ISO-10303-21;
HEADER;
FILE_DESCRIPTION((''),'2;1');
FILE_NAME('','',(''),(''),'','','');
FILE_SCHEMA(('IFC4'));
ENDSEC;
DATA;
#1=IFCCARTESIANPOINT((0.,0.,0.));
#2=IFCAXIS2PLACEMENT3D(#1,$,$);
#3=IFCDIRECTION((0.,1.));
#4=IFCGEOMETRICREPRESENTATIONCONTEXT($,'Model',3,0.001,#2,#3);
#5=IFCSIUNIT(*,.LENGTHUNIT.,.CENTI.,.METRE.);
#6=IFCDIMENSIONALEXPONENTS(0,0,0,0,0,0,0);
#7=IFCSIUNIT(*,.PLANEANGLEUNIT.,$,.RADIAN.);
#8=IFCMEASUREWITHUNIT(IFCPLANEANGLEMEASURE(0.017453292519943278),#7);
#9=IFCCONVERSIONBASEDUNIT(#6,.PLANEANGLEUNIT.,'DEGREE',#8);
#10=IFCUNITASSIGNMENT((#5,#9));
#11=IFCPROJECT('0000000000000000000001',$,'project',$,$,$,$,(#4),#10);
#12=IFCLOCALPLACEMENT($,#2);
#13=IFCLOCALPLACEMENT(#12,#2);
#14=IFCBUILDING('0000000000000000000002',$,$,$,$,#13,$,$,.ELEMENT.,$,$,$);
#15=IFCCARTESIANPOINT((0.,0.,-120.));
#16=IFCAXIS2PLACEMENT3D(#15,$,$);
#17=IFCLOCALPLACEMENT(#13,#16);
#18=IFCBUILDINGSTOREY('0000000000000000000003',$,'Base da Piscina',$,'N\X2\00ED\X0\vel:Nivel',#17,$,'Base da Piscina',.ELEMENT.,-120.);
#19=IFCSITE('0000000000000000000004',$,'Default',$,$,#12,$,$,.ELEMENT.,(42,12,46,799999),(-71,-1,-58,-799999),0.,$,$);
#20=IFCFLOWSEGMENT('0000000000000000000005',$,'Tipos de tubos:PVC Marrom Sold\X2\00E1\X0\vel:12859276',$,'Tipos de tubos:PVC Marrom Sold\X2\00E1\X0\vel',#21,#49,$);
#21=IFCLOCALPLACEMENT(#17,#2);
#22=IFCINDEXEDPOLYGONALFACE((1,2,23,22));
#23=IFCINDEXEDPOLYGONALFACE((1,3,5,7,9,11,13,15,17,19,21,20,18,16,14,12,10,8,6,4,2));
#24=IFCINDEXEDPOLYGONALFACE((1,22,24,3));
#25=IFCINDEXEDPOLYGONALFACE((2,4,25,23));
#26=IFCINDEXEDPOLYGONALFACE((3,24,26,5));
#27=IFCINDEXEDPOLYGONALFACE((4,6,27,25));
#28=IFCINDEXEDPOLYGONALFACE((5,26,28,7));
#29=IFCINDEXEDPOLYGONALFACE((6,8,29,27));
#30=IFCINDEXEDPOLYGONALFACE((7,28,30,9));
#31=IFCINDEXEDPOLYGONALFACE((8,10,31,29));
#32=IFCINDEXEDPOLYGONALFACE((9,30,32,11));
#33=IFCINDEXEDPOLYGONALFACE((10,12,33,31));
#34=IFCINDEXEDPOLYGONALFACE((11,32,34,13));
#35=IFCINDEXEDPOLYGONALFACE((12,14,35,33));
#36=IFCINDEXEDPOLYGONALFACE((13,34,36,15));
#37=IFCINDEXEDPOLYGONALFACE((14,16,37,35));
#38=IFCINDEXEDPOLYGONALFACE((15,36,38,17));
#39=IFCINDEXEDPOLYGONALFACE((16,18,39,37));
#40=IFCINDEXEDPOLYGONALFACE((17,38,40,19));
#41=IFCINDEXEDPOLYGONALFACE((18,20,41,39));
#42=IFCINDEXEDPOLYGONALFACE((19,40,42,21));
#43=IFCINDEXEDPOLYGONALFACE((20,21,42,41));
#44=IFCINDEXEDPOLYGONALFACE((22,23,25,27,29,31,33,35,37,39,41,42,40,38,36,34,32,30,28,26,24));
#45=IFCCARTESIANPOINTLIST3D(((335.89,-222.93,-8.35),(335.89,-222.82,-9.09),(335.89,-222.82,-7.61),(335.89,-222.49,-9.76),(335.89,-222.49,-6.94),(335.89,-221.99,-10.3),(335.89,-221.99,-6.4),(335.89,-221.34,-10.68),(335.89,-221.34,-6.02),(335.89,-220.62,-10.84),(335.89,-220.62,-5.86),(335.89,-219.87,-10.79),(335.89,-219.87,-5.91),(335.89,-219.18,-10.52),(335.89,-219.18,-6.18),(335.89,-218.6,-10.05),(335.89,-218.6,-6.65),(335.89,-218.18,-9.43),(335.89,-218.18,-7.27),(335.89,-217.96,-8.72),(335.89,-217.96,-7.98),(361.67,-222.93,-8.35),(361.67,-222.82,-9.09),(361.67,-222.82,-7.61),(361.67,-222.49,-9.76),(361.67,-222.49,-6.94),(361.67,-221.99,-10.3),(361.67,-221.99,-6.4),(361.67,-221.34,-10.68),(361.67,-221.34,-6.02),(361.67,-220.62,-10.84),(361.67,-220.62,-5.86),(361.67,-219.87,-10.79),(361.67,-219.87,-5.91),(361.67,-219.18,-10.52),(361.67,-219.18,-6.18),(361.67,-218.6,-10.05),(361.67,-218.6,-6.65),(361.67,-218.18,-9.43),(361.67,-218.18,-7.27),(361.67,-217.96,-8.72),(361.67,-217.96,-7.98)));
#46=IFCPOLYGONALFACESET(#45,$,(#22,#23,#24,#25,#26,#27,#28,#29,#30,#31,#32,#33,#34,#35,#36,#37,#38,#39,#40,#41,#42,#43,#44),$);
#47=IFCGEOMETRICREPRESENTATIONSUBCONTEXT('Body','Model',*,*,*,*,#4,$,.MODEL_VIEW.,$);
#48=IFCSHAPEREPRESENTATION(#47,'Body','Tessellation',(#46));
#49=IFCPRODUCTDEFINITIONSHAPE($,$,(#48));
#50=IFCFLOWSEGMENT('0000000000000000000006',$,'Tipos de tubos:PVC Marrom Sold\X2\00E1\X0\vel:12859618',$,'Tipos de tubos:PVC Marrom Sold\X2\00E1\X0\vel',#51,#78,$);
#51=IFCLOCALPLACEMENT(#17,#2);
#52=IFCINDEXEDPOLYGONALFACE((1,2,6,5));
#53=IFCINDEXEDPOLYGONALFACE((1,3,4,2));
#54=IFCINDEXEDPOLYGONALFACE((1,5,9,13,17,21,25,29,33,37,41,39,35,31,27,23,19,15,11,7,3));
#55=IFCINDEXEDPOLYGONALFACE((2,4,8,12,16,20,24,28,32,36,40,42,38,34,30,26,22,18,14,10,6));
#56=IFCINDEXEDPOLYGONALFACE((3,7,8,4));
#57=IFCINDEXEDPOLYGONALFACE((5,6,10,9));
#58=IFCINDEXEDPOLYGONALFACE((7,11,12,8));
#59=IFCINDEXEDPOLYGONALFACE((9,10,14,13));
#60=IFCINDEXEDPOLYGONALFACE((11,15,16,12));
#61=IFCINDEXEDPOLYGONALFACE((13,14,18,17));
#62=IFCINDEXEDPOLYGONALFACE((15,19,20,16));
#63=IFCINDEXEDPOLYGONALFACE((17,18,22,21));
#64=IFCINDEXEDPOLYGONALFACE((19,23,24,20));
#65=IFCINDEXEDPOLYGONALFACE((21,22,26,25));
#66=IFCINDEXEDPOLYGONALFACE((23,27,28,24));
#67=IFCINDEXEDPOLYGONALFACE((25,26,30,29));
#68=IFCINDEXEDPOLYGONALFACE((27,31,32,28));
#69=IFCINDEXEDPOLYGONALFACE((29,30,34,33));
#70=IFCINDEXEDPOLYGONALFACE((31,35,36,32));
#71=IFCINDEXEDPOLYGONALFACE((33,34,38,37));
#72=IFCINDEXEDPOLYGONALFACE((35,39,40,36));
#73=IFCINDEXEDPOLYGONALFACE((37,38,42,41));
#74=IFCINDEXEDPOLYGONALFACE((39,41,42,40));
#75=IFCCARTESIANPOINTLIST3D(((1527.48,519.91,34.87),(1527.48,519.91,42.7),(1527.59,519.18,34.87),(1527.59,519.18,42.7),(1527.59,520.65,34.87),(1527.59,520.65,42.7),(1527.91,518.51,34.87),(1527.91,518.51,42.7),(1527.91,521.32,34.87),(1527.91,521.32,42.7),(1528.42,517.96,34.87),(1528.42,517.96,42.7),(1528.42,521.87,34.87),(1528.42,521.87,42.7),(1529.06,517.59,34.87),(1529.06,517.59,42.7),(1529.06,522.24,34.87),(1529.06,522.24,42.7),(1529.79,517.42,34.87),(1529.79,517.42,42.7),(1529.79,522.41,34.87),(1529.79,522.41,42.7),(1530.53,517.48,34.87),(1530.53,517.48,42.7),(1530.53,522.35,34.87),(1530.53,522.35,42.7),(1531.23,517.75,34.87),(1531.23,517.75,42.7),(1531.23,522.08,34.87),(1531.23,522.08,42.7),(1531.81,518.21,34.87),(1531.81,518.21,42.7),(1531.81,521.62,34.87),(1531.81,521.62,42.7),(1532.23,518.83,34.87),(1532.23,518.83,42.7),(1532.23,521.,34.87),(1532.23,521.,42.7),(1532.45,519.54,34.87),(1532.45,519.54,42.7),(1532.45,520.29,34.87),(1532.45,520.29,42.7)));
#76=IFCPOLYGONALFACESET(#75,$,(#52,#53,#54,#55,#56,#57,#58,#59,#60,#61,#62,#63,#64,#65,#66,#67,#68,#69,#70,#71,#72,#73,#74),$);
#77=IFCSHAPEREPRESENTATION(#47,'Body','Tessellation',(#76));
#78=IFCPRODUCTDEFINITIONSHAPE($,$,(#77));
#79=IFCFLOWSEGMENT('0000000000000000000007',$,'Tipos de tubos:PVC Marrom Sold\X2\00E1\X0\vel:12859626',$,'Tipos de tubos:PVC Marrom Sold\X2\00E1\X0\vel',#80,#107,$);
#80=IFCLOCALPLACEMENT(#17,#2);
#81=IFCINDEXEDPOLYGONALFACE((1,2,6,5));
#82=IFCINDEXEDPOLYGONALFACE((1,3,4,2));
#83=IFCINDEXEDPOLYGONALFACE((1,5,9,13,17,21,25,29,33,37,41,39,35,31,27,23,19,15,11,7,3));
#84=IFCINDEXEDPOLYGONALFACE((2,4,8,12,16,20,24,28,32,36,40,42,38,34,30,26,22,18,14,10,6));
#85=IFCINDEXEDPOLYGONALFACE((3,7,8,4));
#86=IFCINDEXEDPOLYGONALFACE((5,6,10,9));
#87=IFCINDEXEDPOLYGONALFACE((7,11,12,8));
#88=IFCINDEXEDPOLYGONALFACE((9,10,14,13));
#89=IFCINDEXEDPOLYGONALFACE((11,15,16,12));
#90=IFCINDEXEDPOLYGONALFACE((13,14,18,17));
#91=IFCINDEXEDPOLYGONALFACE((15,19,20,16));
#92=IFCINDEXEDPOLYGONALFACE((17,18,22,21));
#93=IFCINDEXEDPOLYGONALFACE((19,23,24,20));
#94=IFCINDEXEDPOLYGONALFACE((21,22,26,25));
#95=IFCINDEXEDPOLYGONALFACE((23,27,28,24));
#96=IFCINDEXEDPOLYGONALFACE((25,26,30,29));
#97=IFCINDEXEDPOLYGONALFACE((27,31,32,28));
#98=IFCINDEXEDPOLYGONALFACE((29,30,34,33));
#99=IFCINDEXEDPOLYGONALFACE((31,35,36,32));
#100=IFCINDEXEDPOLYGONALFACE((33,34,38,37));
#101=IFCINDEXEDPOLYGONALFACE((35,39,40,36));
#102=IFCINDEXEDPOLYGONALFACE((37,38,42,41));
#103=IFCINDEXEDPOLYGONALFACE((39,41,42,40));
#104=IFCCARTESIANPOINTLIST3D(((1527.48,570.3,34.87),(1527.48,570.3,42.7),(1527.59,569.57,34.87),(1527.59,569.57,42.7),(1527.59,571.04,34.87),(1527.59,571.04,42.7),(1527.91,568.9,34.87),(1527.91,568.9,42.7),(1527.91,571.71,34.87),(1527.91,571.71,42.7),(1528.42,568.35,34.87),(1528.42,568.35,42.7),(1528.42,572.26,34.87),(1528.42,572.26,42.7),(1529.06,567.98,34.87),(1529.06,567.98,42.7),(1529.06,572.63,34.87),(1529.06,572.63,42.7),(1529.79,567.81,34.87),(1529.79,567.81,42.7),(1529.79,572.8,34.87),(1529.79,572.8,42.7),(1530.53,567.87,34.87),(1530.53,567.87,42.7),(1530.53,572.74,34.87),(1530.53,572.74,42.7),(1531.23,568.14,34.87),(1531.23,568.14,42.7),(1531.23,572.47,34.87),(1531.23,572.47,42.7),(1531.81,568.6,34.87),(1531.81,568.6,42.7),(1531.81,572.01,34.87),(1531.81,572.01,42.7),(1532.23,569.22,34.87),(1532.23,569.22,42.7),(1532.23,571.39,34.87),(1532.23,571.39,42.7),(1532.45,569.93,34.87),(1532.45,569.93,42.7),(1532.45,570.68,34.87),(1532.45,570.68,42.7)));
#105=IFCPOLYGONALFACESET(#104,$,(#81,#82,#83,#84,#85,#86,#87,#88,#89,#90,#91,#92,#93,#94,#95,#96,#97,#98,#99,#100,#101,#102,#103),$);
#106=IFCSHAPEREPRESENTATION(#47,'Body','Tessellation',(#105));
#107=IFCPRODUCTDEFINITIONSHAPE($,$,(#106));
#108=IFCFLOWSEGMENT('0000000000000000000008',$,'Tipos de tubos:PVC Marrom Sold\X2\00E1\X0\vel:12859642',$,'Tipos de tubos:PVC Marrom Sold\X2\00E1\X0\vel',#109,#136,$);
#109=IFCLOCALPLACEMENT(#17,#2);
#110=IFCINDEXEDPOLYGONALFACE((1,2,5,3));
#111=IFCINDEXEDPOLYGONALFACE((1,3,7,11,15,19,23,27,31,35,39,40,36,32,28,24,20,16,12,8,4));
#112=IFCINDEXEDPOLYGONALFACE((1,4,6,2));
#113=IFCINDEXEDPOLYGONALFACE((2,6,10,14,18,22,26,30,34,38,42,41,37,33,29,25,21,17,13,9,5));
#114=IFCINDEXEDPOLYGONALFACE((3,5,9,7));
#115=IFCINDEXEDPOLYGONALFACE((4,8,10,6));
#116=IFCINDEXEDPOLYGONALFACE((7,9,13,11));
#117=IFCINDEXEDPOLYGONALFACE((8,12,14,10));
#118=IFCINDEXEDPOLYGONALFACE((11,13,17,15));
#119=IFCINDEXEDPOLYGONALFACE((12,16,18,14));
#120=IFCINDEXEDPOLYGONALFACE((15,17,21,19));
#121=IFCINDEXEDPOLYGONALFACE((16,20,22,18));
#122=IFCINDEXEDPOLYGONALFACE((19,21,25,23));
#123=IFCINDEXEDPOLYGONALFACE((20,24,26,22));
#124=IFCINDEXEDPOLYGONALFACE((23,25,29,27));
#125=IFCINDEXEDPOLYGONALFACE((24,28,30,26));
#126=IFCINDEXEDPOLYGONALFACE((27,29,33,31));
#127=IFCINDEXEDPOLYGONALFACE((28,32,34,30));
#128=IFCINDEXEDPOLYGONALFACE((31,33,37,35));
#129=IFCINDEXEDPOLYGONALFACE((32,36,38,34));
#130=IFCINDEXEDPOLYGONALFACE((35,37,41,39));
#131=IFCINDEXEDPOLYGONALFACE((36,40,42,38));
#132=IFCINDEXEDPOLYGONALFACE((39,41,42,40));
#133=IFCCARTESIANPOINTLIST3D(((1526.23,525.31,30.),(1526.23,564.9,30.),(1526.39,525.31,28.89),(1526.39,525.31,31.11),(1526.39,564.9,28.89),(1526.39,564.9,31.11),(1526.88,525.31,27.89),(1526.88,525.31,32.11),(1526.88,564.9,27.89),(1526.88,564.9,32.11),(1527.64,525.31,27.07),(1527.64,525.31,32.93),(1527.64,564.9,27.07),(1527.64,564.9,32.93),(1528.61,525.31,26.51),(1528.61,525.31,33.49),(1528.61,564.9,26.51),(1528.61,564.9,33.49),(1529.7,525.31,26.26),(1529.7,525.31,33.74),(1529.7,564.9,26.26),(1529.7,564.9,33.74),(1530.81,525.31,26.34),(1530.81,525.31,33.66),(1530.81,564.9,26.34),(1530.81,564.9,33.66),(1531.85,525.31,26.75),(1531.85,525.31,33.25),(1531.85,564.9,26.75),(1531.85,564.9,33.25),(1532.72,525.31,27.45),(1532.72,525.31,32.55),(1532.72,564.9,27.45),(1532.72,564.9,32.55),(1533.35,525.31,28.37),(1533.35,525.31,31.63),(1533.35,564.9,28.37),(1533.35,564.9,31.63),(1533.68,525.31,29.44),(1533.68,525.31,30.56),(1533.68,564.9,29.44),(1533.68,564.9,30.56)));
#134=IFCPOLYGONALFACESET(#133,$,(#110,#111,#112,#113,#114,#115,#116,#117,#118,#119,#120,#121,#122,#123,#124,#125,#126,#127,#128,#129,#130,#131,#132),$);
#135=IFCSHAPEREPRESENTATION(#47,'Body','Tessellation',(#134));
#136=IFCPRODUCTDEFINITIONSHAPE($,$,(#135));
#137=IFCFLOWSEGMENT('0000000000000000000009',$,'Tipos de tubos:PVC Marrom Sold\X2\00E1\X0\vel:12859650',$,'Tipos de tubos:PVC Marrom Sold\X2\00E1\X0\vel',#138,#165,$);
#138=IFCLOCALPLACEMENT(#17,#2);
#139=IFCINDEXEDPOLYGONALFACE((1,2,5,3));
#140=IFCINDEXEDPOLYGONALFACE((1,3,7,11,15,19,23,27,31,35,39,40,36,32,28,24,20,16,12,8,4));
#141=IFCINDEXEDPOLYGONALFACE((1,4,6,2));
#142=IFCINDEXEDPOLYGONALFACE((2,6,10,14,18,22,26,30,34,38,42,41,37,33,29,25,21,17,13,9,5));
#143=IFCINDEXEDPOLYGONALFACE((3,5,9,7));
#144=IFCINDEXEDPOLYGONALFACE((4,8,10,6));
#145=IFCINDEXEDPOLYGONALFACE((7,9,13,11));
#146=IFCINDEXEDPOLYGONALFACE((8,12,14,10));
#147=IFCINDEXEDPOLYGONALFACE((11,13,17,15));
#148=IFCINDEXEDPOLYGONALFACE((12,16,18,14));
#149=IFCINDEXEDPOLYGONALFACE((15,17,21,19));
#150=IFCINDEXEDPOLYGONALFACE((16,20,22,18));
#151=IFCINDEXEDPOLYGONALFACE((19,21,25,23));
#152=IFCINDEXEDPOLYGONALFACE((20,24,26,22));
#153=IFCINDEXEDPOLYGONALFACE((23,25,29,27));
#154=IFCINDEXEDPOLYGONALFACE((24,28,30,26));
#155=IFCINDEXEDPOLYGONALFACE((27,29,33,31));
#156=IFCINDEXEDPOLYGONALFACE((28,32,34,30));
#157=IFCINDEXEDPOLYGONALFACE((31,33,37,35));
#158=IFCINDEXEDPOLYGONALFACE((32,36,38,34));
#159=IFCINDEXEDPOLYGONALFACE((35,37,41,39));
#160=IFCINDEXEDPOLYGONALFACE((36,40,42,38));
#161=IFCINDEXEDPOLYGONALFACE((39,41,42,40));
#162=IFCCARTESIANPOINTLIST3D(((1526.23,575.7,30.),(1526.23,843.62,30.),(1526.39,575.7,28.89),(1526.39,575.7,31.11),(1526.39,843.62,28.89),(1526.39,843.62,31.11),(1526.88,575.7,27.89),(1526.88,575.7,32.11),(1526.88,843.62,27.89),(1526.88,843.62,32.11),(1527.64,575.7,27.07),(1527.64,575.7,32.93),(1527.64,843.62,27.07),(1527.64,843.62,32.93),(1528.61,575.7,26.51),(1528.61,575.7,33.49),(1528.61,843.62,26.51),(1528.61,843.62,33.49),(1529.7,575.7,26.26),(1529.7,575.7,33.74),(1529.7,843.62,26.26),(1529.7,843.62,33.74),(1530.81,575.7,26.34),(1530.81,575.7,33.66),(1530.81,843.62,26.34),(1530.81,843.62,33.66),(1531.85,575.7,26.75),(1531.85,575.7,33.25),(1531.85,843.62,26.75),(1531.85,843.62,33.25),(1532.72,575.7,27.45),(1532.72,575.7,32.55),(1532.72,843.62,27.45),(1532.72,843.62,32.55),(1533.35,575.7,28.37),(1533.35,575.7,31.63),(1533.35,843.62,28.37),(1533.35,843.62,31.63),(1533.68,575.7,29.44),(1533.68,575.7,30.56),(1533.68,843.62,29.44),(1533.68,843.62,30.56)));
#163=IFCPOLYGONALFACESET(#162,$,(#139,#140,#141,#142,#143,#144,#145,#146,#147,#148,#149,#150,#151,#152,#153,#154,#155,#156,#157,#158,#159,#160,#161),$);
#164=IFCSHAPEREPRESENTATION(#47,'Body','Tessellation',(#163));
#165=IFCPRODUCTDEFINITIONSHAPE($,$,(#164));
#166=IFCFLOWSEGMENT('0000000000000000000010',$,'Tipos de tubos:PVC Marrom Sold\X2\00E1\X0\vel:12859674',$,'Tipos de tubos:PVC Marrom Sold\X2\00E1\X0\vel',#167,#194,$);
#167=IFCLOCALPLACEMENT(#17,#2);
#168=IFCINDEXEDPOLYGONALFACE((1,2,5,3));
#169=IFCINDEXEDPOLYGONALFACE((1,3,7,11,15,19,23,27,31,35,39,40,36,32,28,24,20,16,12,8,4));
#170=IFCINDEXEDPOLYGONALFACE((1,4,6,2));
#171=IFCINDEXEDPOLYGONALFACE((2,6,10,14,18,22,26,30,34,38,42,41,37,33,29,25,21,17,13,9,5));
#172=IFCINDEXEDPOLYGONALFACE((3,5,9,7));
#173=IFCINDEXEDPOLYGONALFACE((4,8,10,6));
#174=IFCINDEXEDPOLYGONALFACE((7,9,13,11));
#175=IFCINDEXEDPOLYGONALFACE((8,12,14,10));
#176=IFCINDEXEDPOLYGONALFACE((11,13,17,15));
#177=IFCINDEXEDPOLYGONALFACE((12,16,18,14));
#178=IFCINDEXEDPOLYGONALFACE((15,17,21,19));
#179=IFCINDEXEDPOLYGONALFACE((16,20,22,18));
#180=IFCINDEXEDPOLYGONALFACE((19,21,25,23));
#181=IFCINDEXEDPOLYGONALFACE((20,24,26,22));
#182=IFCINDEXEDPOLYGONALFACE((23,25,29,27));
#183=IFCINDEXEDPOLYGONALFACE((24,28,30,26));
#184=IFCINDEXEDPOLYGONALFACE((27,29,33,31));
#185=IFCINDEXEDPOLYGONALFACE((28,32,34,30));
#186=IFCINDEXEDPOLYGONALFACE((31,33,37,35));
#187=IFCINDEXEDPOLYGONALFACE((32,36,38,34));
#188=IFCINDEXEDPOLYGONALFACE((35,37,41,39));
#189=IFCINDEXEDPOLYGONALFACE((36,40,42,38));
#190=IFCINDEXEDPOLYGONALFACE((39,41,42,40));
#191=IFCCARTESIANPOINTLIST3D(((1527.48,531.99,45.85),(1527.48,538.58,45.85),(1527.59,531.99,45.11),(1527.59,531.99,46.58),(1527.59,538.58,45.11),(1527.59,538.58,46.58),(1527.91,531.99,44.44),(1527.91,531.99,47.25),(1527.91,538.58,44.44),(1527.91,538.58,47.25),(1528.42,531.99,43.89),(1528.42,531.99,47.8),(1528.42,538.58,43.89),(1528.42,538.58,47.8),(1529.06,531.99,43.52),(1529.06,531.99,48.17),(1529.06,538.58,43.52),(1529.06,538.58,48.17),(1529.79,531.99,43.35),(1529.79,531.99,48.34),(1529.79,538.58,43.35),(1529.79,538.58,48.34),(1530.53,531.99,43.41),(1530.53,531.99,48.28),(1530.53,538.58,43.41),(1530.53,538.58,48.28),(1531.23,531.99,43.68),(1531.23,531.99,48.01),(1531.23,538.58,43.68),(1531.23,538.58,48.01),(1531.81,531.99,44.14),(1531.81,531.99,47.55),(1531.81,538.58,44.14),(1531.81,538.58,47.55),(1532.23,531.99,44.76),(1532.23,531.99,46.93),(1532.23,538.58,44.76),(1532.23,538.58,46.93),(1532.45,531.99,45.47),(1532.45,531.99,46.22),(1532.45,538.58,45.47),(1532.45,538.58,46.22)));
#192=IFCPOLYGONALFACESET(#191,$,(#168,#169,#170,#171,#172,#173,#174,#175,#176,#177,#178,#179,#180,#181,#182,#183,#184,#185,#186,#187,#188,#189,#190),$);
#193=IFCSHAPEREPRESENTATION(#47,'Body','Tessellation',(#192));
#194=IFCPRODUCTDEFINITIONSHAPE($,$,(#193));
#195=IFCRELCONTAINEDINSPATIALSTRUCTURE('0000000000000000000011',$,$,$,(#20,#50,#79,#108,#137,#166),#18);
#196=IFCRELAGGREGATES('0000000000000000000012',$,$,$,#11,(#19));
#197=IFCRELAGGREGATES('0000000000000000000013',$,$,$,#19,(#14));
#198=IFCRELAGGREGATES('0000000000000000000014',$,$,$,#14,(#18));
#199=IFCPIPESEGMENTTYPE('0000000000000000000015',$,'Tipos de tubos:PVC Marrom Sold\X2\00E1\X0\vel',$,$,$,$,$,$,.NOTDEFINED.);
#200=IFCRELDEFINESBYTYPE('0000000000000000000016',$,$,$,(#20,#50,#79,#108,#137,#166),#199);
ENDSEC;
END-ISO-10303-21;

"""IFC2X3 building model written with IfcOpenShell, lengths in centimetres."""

from ifc_helpers import new_model, entity, si_unit, converted_unit, direction, frame, frame_2d, origin, place, context, subcontext, project, spatial, circle, extrude, type_object, element, save


model = new_model("IFC2X3")

# Units and contexts
model_context = context("Model", 3, precision=0.001, world=origin(), true_north=direction((0.0, 1.0)))
body_context = subcontext(model_context, "Body", "Model", "MODEL_VIEW")
ifc_project = project(units=[si_unit("LENGTHUNIT", "METRE", prefix="CENTI"), converted_unit("PLANEANGLEUNIT", "DEGREE", entity("IfcPlaneAngleMeasure", 0.017453292519943278), si_unit("PLANEANGLEUNIT", "RADIAN"), dimensions=[0, 0, 0, 0, 0, 0, 0])], contexts=[model_context])

# Site, building, storey
site_placement = place(None, origin())
site = spatial("IfcSite", under=ifc_project, at=site_placement, Name="Default", CompositionType="ELEMENT", RefLatitude=(42, 12, 46, 799999), RefLongitude=(-71, -1, -58, -799999), RefElevation=0.0)
building_placement = place(site_placement, origin())
building = spatial("IfcBuilding", under=site, at=building_placement, CompositionType="ELEMENT")
storey_placement = place(building_placement, frame((0.0, 0.0, -120.0)))
storey = spatial("IfcBuildingStorey", under=building, at=storey_placement, Name="Base da Piscina", ObjectType="Nível:Nivel", LongName="Base da Piscina", CompositionType="ELEMENT", Elevation=-120.0)

# Flow segments
pipe_segment_type = type_object("IfcPipeSegmentType", Name="Tipos de tubos:PVC Marrom Soldável", PredefinedType="NOTDEFINED")
flow_segment_1_placement = place(storey_placement, origin())
element("IfcFlowSegment", 1, at=flow_segment_1_placement, inside=storey, type_object=pipe_segment_type, Name="Tipos de tubos:PVC Marrom Soldável:12859276", ObjectType="Tipos de tubos:PVC Marrom Soldável", context=body_context, shape_type="SweptSolid", body=[
    extrude(circle(Radius=2.5, at=frame_2d((0.0, 0.0), x_axis=(1.0, 0.0))), frame((335.89, -220.43, -8.35), z_axis=(1.0, 0.0, 0.0), x_axis=(0.0, -1.0, 0.0)), (0.0, 0.0, 1.0), 25.78),
])
flow_segment_2_placement = place(storey_placement, origin())
element("IfcFlowSegment", 2, at=flow_segment_2_placement, inside=storey, type_object=pipe_segment_type, Name="Tipos de tubos:PVC Marrom Soldável:12859618", ObjectType="Tipos de tubos:PVC Marrom Soldável", context=body_context, shape_type="SweptSolid", body=[
    extrude(circle(Radius=2.5, at=frame_2d((0.0, 0.0), x_axis=(1.0, 0.0))), frame((1529.98, 519.91, 34.87), z_axis=(0.0, 0.0, 1.0), x_axis=(-1.0, 0.0, 0.0)), (0.0, 0.0, 1.0), 7.83),
])
flow_segment_3_placement = place(storey_placement, origin())
element("IfcFlowSegment", 3, at=flow_segment_3_placement, inside=storey, type_object=pipe_segment_type, Name="Tipos de tubos:PVC Marrom Soldável:12859626", ObjectType="Tipos de tubos:PVC Marrom Soldável", context=body_context, shape_type="SweptSolid", body=[
    extrude(circle(Radius=2.5, at=frame_2d((0.0, 0.0), x_axis=(1.0, 0.0))), frame((1529.98, 570.3, 34.87), z_axis=(0.0, 0.0, 1.0), x_axis=(-1.0, 0.0, 0.0)), (0.0, 0.0, 1.0), 7.83),
])
flow_segment_4_placement = place(storey_placement, origin())
element("IfcFlowSegment", 4, at=flow_segment_4_placement, inside=storey, type_object=pipe_segment_type, Name="Tipos de tubos:PVC Marrom Soldável:12859642", ObjectType="Tipos de tubos:PVC Marrom Soldável", context=body_context, shape_type="SweptSolid", body=[
    extrude(circle(Radius=3.75, at=frame_2d((0.0, 0.0), x_axis=(1.0, 0.0))), frame((1529.98, 525.31, 30.0), z_axis=(0.0, 1.0, 0.0), x_axis=(-1.0, 0.0, 0.0)), (0.0, 0.0, 1.0), 39.59),
])
flow_segment_5_placement = place(storey_placement, origin())
element("IfcFlowSegment", 5, at=flow_segment_5_placement, inside=storey, type_object=pipe_segment_type, Name="Tipos de tubos:PVC Marrom Soldável:12859650", ObjectType="Tipos de tubos:PVC Marrom Soldável", context=body_context, shape_type="SweptSolid", body=[
    extrude(circle(Radius=3.75, at=frame_2d((0.0, 0.0), x_axis=(1.0, 0.0))), frame((1529.98, 575.7, 30.0), z_axis=(0.0, 1.0, 0.0), x_axis=(-1.0, 0.0, 0.0)), (0.0, 0.0, 1.0), 267.92),
])
flow_segment_6_placement = place(storey_placement, origin())
element("IfcFlowSegment", 6, at=flow_segment_6_placement, inside=storey, type_object=pipe_segment_type, Name="Tipos de tubos:PVC Marrom Soldável:12859674", ObjectType="Tipos de tubos:PVC Marrom Soldável", context=body_context, shape_type="SweptSolid", body=[
    extrude(circle(Radius=2.5, at=frame_2d((0.0, 0.0), x_axis=(1.0, 0.0))), frame((1529.98, 531.99, 45.85), z_axis=(0.0, 1.0, 0.0), x_axis=(-1.0, 0.0, 0.0)), (0.0, 0.0, 1.0), 6.59),
])

save(model, "model.ifc")
